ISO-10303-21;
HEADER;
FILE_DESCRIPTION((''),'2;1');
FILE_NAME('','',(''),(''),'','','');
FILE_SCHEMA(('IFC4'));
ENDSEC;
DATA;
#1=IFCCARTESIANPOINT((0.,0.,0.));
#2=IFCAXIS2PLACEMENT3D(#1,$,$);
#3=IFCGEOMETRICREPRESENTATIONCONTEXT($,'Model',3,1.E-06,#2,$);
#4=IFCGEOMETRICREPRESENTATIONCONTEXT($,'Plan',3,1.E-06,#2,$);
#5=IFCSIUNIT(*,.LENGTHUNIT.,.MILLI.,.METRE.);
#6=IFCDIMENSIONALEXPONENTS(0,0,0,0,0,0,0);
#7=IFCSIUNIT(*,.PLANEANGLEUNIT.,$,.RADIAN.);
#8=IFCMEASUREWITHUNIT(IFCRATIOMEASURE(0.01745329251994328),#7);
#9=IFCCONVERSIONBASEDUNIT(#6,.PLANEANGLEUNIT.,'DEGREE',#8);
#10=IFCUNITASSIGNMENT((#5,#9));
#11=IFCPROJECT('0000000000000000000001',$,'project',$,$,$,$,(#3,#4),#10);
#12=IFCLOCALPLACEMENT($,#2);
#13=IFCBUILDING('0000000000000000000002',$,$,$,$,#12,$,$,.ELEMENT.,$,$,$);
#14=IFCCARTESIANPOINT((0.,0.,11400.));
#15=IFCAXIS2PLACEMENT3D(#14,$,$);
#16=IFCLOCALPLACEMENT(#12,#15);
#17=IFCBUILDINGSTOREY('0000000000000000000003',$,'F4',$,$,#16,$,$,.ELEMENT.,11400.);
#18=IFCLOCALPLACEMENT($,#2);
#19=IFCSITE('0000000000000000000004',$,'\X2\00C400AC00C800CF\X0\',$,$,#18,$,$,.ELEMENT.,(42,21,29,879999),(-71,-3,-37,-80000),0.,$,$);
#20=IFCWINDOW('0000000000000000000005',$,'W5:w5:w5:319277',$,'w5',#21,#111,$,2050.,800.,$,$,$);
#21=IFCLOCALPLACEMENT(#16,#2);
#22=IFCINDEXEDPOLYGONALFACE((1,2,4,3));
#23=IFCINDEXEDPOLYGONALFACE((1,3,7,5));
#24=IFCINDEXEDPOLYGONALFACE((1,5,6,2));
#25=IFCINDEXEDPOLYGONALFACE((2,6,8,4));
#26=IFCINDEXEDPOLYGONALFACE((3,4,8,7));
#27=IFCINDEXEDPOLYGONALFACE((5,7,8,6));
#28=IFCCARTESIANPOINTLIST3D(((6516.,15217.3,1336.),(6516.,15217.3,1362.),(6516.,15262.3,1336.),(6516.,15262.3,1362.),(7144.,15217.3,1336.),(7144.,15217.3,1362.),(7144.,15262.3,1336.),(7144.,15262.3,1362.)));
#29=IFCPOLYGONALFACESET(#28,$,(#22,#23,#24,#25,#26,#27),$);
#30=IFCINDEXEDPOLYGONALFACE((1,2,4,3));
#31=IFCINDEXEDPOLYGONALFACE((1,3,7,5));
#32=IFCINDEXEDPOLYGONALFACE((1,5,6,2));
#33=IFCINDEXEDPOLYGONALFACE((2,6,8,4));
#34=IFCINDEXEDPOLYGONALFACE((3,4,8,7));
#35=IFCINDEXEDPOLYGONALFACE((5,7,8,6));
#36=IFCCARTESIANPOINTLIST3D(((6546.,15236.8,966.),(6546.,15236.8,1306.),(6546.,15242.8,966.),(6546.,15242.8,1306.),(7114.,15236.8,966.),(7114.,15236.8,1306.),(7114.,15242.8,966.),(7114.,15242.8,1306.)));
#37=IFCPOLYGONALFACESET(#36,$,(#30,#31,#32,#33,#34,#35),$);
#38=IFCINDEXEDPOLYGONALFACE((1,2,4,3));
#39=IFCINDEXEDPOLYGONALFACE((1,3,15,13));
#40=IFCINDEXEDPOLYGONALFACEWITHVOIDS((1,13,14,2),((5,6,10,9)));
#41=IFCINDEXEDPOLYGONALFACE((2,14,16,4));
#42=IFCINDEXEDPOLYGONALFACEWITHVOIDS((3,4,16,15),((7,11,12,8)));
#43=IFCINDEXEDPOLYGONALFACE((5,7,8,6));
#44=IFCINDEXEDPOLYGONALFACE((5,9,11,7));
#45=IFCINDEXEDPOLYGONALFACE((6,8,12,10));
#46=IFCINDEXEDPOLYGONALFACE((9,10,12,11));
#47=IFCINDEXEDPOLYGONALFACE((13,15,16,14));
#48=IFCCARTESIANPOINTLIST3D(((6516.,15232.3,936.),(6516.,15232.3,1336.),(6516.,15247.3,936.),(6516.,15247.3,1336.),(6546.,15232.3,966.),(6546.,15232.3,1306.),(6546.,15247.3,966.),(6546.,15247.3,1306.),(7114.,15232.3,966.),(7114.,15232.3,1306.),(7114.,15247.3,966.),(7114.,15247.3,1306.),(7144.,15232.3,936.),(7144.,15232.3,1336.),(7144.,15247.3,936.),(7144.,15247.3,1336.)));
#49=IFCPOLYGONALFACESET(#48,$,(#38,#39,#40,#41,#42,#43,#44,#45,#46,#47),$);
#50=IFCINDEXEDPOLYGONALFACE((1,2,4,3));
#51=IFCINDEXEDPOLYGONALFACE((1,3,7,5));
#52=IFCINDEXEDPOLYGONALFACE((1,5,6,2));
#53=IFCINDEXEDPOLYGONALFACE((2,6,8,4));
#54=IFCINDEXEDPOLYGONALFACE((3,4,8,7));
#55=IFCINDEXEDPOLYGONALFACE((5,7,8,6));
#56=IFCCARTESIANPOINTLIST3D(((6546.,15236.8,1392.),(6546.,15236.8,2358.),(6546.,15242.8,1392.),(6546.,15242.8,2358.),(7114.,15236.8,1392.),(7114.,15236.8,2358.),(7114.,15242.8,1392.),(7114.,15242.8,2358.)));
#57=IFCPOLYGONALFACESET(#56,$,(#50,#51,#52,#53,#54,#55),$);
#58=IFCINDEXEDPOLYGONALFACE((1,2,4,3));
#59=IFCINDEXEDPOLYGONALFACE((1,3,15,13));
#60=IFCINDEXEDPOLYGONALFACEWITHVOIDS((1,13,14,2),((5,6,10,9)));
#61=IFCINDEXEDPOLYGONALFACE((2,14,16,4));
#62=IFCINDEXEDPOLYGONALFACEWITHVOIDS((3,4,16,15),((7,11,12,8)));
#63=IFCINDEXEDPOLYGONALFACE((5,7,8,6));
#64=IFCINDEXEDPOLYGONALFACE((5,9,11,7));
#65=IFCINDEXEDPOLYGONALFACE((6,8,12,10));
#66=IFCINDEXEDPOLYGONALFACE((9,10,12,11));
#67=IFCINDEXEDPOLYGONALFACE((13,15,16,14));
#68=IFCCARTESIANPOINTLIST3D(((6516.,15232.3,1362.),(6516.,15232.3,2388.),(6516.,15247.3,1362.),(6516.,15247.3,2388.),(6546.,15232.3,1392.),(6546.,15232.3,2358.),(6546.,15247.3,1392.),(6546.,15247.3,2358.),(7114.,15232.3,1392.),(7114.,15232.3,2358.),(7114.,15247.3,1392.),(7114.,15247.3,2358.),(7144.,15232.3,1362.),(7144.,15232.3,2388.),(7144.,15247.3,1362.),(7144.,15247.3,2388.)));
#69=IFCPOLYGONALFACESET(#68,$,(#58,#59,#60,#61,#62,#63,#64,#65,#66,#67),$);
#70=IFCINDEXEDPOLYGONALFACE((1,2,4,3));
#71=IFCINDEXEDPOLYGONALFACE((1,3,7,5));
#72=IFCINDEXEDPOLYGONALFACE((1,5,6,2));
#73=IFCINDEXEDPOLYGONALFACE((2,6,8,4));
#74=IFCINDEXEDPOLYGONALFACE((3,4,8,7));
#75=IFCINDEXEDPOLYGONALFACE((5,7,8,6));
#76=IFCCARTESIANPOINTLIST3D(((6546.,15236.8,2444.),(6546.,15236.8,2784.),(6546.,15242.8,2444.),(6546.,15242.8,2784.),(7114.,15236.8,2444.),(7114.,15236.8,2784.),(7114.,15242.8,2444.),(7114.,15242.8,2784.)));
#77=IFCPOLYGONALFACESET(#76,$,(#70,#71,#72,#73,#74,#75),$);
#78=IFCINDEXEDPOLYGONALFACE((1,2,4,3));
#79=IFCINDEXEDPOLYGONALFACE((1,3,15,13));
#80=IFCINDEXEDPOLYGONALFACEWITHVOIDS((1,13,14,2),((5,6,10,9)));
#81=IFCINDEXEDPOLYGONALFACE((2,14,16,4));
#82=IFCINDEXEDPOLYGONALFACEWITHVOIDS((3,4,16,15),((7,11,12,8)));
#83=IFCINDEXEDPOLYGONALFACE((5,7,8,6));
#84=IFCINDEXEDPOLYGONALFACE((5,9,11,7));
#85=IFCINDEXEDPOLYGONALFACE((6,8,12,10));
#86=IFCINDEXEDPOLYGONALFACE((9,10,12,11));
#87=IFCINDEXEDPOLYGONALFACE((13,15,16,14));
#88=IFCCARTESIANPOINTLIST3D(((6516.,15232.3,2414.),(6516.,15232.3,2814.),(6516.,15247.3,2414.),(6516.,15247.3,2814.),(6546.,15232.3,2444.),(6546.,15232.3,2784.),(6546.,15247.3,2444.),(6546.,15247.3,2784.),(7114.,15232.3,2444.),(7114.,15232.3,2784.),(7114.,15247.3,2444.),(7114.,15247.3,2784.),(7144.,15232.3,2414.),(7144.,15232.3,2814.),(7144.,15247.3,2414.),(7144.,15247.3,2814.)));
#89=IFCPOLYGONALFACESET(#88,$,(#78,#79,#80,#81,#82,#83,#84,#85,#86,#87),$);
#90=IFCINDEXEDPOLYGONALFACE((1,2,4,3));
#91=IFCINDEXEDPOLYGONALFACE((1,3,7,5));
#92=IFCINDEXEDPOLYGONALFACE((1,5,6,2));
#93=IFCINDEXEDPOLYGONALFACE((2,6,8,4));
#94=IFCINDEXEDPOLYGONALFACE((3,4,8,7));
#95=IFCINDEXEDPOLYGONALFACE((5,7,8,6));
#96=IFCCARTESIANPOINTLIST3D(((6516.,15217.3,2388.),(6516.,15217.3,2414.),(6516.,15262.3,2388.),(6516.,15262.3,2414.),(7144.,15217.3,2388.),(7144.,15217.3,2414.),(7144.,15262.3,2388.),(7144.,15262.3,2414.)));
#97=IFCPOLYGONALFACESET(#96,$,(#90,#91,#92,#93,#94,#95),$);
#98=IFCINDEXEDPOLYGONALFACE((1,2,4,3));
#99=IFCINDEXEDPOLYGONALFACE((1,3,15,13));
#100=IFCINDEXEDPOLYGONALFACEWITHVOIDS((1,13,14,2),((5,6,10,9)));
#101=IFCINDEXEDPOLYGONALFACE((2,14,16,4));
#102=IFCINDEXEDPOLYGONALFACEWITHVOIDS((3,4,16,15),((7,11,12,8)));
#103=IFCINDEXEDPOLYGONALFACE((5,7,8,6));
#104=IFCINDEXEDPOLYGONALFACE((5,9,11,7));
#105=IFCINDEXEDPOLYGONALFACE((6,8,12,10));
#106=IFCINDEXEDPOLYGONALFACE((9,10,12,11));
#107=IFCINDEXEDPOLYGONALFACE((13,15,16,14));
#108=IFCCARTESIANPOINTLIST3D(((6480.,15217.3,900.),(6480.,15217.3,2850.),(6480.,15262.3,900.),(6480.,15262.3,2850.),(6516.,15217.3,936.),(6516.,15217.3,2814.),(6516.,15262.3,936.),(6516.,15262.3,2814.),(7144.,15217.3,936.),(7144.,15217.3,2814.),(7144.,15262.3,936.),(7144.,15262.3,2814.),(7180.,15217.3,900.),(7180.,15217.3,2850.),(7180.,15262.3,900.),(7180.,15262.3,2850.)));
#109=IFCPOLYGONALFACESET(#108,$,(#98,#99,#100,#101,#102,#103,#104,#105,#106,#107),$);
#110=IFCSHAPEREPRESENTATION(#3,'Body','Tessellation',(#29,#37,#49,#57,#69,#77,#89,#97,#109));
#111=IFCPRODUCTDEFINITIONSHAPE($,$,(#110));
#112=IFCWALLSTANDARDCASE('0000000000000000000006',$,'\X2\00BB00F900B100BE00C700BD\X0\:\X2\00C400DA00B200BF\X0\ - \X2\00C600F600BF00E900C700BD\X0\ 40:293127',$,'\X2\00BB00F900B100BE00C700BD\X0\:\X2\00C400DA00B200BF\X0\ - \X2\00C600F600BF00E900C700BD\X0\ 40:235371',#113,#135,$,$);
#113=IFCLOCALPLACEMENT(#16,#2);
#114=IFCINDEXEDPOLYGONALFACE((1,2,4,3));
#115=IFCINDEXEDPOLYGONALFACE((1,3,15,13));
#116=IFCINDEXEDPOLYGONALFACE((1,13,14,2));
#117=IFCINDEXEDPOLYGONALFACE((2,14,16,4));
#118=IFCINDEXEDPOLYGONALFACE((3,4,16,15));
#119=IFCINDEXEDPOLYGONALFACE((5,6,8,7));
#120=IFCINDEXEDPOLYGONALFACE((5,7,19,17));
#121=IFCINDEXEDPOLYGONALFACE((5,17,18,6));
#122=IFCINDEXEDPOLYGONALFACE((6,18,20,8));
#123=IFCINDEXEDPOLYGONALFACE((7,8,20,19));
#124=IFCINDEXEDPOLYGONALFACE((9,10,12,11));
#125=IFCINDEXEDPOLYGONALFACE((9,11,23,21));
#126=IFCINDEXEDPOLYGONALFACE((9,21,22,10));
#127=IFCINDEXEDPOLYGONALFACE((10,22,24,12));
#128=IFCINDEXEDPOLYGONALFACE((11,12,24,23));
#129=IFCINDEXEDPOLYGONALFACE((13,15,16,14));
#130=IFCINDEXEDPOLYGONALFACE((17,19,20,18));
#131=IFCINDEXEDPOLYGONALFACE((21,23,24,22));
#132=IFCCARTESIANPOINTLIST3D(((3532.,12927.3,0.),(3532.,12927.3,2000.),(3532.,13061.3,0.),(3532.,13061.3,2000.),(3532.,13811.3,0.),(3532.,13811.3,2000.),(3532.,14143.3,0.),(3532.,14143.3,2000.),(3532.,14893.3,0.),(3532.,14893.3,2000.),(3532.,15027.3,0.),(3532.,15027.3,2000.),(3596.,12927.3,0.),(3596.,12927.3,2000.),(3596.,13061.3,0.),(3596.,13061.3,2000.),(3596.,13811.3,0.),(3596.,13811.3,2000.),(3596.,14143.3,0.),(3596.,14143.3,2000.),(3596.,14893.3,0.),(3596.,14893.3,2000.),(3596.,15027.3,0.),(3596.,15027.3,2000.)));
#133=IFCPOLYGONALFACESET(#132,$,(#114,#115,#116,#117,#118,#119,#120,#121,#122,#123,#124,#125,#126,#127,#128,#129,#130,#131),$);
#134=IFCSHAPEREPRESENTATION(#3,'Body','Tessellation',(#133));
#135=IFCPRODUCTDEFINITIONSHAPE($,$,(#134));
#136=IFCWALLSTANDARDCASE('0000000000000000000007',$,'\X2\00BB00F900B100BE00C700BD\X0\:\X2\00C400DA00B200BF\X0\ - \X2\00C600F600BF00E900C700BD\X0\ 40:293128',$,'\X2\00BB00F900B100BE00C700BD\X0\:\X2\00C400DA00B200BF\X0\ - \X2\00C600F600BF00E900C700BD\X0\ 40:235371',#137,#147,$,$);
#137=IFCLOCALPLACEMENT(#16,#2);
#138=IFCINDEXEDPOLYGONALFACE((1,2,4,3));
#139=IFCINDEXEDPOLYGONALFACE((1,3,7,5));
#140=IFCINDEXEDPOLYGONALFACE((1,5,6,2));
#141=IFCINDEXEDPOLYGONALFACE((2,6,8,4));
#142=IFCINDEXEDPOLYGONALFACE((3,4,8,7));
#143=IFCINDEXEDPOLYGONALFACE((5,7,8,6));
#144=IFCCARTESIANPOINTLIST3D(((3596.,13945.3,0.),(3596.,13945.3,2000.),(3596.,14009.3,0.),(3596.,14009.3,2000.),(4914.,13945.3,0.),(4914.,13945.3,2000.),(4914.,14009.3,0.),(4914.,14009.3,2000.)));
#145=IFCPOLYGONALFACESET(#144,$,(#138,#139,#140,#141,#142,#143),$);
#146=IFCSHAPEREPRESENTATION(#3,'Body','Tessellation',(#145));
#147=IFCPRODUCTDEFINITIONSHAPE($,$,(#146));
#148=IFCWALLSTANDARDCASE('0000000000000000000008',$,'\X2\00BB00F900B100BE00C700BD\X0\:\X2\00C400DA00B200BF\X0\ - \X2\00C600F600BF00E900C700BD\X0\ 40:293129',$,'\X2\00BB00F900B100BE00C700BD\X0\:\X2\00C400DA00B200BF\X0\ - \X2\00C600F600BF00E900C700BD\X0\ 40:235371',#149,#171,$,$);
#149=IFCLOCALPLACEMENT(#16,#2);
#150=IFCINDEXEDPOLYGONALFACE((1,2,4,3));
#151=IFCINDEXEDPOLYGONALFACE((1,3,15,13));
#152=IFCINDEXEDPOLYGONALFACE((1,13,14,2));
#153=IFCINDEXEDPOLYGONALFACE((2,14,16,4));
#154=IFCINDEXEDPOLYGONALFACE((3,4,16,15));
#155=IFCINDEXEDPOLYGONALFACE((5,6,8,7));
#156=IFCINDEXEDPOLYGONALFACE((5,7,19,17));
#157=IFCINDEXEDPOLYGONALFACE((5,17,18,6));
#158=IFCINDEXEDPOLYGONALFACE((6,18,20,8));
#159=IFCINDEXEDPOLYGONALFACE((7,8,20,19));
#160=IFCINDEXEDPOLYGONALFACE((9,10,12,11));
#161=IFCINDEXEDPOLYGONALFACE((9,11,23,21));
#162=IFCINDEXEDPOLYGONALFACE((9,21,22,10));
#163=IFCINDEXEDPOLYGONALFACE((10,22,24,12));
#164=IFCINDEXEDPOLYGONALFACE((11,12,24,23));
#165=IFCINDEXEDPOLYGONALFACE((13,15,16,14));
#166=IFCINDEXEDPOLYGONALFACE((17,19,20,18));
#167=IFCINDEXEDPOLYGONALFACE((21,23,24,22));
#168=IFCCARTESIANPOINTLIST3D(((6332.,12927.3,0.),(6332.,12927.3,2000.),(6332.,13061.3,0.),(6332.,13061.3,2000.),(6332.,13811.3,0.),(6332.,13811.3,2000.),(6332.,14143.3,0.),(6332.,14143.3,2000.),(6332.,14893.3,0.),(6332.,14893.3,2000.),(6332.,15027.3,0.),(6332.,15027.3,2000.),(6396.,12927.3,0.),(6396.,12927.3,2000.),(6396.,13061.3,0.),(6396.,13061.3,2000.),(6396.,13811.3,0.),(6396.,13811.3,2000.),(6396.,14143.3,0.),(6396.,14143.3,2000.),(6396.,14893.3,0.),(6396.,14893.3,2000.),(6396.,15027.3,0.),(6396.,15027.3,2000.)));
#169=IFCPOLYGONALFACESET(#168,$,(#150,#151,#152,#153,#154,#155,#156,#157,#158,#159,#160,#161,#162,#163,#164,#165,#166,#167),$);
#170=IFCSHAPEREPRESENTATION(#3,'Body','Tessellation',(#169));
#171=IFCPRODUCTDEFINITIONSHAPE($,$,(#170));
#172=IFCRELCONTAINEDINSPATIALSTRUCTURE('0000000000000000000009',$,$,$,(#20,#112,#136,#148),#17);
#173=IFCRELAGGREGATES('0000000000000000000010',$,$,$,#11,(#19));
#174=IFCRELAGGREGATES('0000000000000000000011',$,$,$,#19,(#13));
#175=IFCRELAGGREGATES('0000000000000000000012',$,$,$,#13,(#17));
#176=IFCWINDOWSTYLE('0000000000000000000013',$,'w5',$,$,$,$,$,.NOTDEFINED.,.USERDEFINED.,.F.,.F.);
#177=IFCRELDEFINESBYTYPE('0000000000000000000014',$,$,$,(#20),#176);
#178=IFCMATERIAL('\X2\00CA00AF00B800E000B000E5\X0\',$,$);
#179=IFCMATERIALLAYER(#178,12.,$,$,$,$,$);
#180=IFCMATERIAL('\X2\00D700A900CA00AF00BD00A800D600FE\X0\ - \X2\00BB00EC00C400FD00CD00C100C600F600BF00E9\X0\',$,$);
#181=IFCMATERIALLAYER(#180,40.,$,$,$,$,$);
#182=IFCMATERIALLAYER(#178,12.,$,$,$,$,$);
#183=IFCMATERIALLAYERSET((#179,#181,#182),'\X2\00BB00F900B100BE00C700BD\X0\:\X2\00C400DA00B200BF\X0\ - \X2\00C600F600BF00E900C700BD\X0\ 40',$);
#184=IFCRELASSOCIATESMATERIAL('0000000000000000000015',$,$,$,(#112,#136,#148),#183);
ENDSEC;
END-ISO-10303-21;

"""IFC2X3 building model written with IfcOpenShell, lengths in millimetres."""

from ifc_helpers import new_model, entity, si_unit, converted_unit, frame, frame_2d, origin, origin_2d_with_axis, place, context, project, spatial, polyline, rectangle, outline, extrude, clip, source, transform, mapped, material, layer, layer_set, layer_usage, type_object, type_shapes, element, save


model = new_model("IFC2X3")

# Units and contexts
model_context = context("Model", 3, precision=1e-06, world=origin())
plan_context = context("Plan", 3, precision=1e-06, world=origin())
ifc_project = project(units=[si_unit("LENGTHUNIT", "METRE", prefix="MILLI"), converted_unit("PLANEANGLEUNIT", "DEGREE", entity("IfcRatioMeasure", 0.01745329251994328), si_unit("PLANEANGLEUNIT", "RADIAN"), dimensions=[0, 0, 0, 0, 0, 0, 0])], contexts=[model_context, plan_context])

# Site, building, storey
site_placement = place(None, origin())
site = spatial("IfcSite", under=ifc_project, at=site_placement, Name="Ä¬ÈÏ", CompositionType="ELEMENT", RefLatitude=(42, 21, 29, 879999), RefLongitude=(-71, -3, -37, -80000), RefElevation=0.0)
building_placement = place(None, origin())
building = spatial("IfcBuilding", under=site, at=building_placement, CompositionType="ELEMENT")
storey_placement = place(building_placement, frame((0.0, 0.0, 11400.0)))
storey = spatial("IfcBuildingStorey", under=building, at=storey_placement, Name="F4", CompositionType="ELEMENT", Elevation=11400.0)

# Window
window_style = type_object("IfcWindowStyle", Name="w5", ConstructionType="NOTDEFINED", OperationType="USERDEFINED", ParameterTakesPrecedence=False, Sizeable=False)
shared_shape = source(origin(), model_context, "Body", "SweptSolid", [
    extrude(rectangle(XDim=45.0, YDim=628.0, at=origin_2d_with_axis()), frame((350.0, -248.1, 436.0), z_axis=(0.0, 0.0, 1.0), x_axis=(0.0, 1.0, 0.0)), (0.0, 0.0, 1.0), 26.0),
    extrude(rectangle(XDim=6.0, YDim=568.0, at=origin_2d_with_axis()), frame((350.0, -248.1, 66.0), z_axis=(0.0, 0.0, 1.0), x_axis=(0.0, 1.0, 0.0)), (0.0, 0.0, 1.0), 340.0),
    extrude(outline(polyline([(-200.0, -314.0), (200.0, -314.0), (200.0, 314.0), (-200.0, 314.0), (-200.0, -314.0)]), holes=[polyline([(170.0, -284.0), (-170.0, -284.0), (-170.0, 284.0), (170.0, 284.0), (170.0, -284.0)])]), frame((350.0, -255.6, 236.0), z_axis=(0.0, 1.0, 0.0), x_axis=(0.0, 0.0, 1.0)), (0.0, 0.0, 1.0), 15.0),
    extrude(rectangle(XDim=6.0, YDim=568.0, at=origin_2d_with_axis()), frame((350.0, -248.1, 492.0), z_axis=(0.0, 0.0, 1.0), x_axis=(0.0, 1.0, 0.0)), (0.0, 0.0, 1.0), 966.0),
    extrude(outline(polyline([(-513.0, -314.0), (513.0, -314.0), (513.0, 314.0), (-513.0, 314.0), (-513.0, -314.0)]), holes=[polyline([(483.0, -284.0), (-483.0, -284.0), (-483.0, 284.0), (483.0, 284.0), (483.0, -284.0)])]), frame((350.0, -255.6, 975.0), z_axis=(0.0, 1.0, 0.0), x_axis=(0.0, 0.0, 1.0)), (0.0, 0.0, 1.0), 15.0),
    extrude(rectangle(XDim=6.0, YDim=568.0, at=origin_2d_with_axis()), frame((350.0, -248.1, 1544.0), z_axis=(0.0, 0.0, 1.0), x_axis=(0.0, 1.0, 0.0)), (0.0, 0.0, 1.0), 340.0),
    extrude(outline(polyline([(-200.0, -314.0), (200.0, -314.0), (200.0, 314.0), (-200.0, 314.0), (-200.0, -314.0)]), holes=[polyline([(170.0, -284.0), (-170.0, -284.0), (-170.0, 284.0), (170.0, 284.0), (170.0, -284.0)])]), frame((350.0, -255.6, 1714.0), z_axis=(0.0, 1.0, 0.0), x_axis=(0.0, 0.0, 1.0)), (0.0, 0.0, 1.0), 15.0),
    extrude(rectangle(XDim=45.0, YDim=628.0, at=origin_2d_with_axis()), frame((350.0, -248.1, 1488.0), z_axis=(0.0, 0.0, 1.0), x_axis=(0.0, 1.0, 0.0)), (0.0, 0.0, 1.0), 26.0),
    extrude(outline(polyline([(-975.0, -350.0), (975.0, -350.0), (975.0, 350.0), (-975.0, 350.0), (-975.0, -350.0)]), holes=[polyline([(939.0, -314.0), (-939.0, -314.0), (-939.0, 314.0), (939.0, 314.0), (939.0, -314.0)])]), frame((350.0, -270.6, 975.0), z_axis=(0.0, 1.0, 0.0), x_axis=(0.0, 0.0, 1.0)), (0.0, 0.0, 1.0), 45.0),
])
type_shapes(window_style, [shared_shape])
for number, where, name in (
    (1, (6480.0, 15487.9, 900.0), "W5:w5:w5:319277"),
):
    element("IfcWindow", number, at=place(storey_placement, frame(where)), inside=storey, type_object=window_style, Name=name, ObjectType="w5", OverallHeight=2050.0, OverallWidth=800.0, context=model_context, shape_type="MappedRepresentation", body=[
        mapped(shared_shape, transform((0.0, 0.0, 0.0), scale=1.0)),
    ])

# Wall, openings
ifc_material_1 = material(Name="Ê¯¸à°å")
ifc_layer_1 = layer(ifc_material_1, 12.0)
ifc_material_2 = material(Name="×©Ê¯½¨Öþ - »ìÄýÍÁÆö¿é")
ifc_layer_2 = layer(ifc_material_2, 40.0)
ifc_layer_3 = layer(ifc_material_1, 12.0)
ifc_layer_set_1 = layer_set([ifc_layer_1, ifc_layer_2, ifc_layer_3], Name="»ù±¾Ç½:ÄÚ²¿ - Æö¿éÇ½ 40")
ifc_layer_usage_1 = layer_usage(ifc_layer_set_1, "AXIS2", "NEGATIVE", 32.0)
wall_1_placement = place(storey_placement, frame((3564.0, 15027.3, 0.0), z_axis=(0.0, 0.0, 1.0), x_axis=(0.0, -1.0, 0.0)))
wall_1 = element("IfcWallStandardCase", 2, at=wall_1_placement, inside=storey, material=ifc_layer_usage_1, Name="»ù±¾Ç½:ÄÚ²¿ - Æö¿éÇ½ 40:293127", ObjectType="»ù±¾Ç½:ÄÚ²¿ - Æö¿éÇ½ 40:235371", context=model_context, shape_type="SweptSolid", body=[
    extrude(rectangle(XDim=2100.0, YDim=64.0, at=frame_2d((1050.0, 0.0), x_axis=(-1.0, 0.0))), origin(), (0.0, 0.0, 1.0), 2000.0),
])
opening_1_placement = place(wall_1_placement, frame((134.0, -32.0, 0.0)))
element("IfcOpeningElement", 3, at=opening_1_placement, cuts=wall_1, ObjectType="Opening", context=model_context, shape_type="SweptSolid", body=[
    extrude(rectangle(XDim=2000.0, YDim=750.0, at=frame_2d((1000.0, 375.0), x_axis=(1.0, 0.0))), frame((0.0, 0.0, 0.0), z_axis=(0.0, 1.0, 0.0), x_axis=(0.0, 0.0, 1.0)), (0.0, 0.0, 1.0), 64.0),
])
opening_2_placement = place(wall_1_placement, frame((1216.0, -32.0, 0.0)))
element("IfcOpeningElement", 4, at=opening_2_placement, cuts=wall_1, ObjectType="Opening", context=model_context, shape_type="SweptSolid", body=[
    extrude(rectangle(XDim=2000.0, YDim=750.0, at=frame_2d((1000.0, 375.0), x_axis=(1.0, 0.0))), frame((0.0, 0.0, 0.0), z_axis=(0.0, 1.0, 0.0), x_axis=(0.0, 0.0, 1.0)), (0.0, 0.0, 1.0), 64.0),
])

# Wall
ifc_layer_usage_2 = layer_usage(ifc_layer_set_1, "AXIS2", "NEGATIVE", 32.0)
wall_2_placement = place(storey_placement, frame((3596.0, 13977.3, 0.0)))
element("IfcWallStandardCase", 5, at=wall_2_placement, inside=storey, material=ifc_layer_usage_2, Name="»ù±¾Ç½:ÄÚ²¿ - Æö¿éÇ½ 40:293128", ObjectType="»ù±¾Ç½:ÄÚ²¿ - Æö¿éÇ½ 40:235371", context=model_context, shape_type="Clipping", body=[
    clip(extrude(rectangle(XDim=2736.0, YDim=64.0, at=frame_2d((1368.0, 0.0), x_axis=(-1.0, 0.0))), origin(), (0.0, 0.0, 1.0), 2000.0), entity("IfcBoxedHalfSpace", entity("IfcPlane", entity("IfcAxis2Placement3D", entity("IfcCartesianPoint", [1318.0, 0.0, 1000.0]), entity("IfcDirection", [1.0, 0.0, 0.0]), entity("IfcDirection", [0.0, 1.0, 0.0]))), False, entity("IfcBoundingBox", entity("IfcCartesianPoint", [32.0, -1000.0, 0.0]), 64.0, 2000.0, 100.0))),
])

# Wall, openings
ifc_layer_usage_3 = layer_usage(ifc_layer_set_1, "AXIS2", "POSITIVE", -32.0)
wall_3_placement = place(storey_placement, frame((6364.0, 15027.3, 0.0), z_axis=(0.0, 0.0, 1.0), x_axis=(0.0, -1.0, 0.0)))
wall_3 = element("IfcWallStandardCase", 6, at=wall_3_placement, inside=storey, material=ifc_layer_usage_3, Name="»ù±¾Ç½:ÄÚ²¿ - Æö¿éÇ½ 40:293129", ObjectType="»ù±¾Ç½:ÄÚ²¿ - Æö¿éÇ½ 40:235371", context=model_context, shape_type="SweptSolid", body=[
    extrude(rectangle(XDim=2100.0, YDim=64.0, at=frame_2d((1050.0, 0.0), x_axis=(-1.0, 0.0))), origin(), (0.0, 0.0, 1.0), 2000.0),
])
opening_3_placement = place(wall_3_placement, frame((884.0, 32.0, 0.0)))
element("IfcOpeningElement", 7, at=opening_3_placement, cuts=wall_3, ObjectType="Opening", context=model_context, shape_type="SweptSolid", body=[
    extrude(rectangle(XDim=2000.0, YDim=750.0, at=frame_2d((1000.0, 375.0), x_axis=(1.0, 0.0))), frame((0.0, 0.0, 0.0), z_axis=(0.0, -1.0, 0.0), x_axis=(0.0, 0.0, 1.0)), (0.0, 0.0, 1.0), 64.0),
])
opening_4_placement = place(wall_3_placement, frame((1966.0, 32.0, 0.0)))
element("IfcOpeningElement", 8, at=opening_4_placement, cuts=wall_3, ObjectType="Opening", context=model_context, shape_type="SweptSolid", body=[
    extrude(rectangle(XDim=2000.0, YDim=750.0, at=frame_2d((1000.0, 375.0), x_axis=(1.0, 0.0))), frame((0.0, 0.0, 0.0), z_axis=(0.0, -1.0, 0.0), x_axis=(0.0, 0.0, 1.0)), (0.0, 0.0, 1.0), 64.0),
])

save(model, "model.ifc")
